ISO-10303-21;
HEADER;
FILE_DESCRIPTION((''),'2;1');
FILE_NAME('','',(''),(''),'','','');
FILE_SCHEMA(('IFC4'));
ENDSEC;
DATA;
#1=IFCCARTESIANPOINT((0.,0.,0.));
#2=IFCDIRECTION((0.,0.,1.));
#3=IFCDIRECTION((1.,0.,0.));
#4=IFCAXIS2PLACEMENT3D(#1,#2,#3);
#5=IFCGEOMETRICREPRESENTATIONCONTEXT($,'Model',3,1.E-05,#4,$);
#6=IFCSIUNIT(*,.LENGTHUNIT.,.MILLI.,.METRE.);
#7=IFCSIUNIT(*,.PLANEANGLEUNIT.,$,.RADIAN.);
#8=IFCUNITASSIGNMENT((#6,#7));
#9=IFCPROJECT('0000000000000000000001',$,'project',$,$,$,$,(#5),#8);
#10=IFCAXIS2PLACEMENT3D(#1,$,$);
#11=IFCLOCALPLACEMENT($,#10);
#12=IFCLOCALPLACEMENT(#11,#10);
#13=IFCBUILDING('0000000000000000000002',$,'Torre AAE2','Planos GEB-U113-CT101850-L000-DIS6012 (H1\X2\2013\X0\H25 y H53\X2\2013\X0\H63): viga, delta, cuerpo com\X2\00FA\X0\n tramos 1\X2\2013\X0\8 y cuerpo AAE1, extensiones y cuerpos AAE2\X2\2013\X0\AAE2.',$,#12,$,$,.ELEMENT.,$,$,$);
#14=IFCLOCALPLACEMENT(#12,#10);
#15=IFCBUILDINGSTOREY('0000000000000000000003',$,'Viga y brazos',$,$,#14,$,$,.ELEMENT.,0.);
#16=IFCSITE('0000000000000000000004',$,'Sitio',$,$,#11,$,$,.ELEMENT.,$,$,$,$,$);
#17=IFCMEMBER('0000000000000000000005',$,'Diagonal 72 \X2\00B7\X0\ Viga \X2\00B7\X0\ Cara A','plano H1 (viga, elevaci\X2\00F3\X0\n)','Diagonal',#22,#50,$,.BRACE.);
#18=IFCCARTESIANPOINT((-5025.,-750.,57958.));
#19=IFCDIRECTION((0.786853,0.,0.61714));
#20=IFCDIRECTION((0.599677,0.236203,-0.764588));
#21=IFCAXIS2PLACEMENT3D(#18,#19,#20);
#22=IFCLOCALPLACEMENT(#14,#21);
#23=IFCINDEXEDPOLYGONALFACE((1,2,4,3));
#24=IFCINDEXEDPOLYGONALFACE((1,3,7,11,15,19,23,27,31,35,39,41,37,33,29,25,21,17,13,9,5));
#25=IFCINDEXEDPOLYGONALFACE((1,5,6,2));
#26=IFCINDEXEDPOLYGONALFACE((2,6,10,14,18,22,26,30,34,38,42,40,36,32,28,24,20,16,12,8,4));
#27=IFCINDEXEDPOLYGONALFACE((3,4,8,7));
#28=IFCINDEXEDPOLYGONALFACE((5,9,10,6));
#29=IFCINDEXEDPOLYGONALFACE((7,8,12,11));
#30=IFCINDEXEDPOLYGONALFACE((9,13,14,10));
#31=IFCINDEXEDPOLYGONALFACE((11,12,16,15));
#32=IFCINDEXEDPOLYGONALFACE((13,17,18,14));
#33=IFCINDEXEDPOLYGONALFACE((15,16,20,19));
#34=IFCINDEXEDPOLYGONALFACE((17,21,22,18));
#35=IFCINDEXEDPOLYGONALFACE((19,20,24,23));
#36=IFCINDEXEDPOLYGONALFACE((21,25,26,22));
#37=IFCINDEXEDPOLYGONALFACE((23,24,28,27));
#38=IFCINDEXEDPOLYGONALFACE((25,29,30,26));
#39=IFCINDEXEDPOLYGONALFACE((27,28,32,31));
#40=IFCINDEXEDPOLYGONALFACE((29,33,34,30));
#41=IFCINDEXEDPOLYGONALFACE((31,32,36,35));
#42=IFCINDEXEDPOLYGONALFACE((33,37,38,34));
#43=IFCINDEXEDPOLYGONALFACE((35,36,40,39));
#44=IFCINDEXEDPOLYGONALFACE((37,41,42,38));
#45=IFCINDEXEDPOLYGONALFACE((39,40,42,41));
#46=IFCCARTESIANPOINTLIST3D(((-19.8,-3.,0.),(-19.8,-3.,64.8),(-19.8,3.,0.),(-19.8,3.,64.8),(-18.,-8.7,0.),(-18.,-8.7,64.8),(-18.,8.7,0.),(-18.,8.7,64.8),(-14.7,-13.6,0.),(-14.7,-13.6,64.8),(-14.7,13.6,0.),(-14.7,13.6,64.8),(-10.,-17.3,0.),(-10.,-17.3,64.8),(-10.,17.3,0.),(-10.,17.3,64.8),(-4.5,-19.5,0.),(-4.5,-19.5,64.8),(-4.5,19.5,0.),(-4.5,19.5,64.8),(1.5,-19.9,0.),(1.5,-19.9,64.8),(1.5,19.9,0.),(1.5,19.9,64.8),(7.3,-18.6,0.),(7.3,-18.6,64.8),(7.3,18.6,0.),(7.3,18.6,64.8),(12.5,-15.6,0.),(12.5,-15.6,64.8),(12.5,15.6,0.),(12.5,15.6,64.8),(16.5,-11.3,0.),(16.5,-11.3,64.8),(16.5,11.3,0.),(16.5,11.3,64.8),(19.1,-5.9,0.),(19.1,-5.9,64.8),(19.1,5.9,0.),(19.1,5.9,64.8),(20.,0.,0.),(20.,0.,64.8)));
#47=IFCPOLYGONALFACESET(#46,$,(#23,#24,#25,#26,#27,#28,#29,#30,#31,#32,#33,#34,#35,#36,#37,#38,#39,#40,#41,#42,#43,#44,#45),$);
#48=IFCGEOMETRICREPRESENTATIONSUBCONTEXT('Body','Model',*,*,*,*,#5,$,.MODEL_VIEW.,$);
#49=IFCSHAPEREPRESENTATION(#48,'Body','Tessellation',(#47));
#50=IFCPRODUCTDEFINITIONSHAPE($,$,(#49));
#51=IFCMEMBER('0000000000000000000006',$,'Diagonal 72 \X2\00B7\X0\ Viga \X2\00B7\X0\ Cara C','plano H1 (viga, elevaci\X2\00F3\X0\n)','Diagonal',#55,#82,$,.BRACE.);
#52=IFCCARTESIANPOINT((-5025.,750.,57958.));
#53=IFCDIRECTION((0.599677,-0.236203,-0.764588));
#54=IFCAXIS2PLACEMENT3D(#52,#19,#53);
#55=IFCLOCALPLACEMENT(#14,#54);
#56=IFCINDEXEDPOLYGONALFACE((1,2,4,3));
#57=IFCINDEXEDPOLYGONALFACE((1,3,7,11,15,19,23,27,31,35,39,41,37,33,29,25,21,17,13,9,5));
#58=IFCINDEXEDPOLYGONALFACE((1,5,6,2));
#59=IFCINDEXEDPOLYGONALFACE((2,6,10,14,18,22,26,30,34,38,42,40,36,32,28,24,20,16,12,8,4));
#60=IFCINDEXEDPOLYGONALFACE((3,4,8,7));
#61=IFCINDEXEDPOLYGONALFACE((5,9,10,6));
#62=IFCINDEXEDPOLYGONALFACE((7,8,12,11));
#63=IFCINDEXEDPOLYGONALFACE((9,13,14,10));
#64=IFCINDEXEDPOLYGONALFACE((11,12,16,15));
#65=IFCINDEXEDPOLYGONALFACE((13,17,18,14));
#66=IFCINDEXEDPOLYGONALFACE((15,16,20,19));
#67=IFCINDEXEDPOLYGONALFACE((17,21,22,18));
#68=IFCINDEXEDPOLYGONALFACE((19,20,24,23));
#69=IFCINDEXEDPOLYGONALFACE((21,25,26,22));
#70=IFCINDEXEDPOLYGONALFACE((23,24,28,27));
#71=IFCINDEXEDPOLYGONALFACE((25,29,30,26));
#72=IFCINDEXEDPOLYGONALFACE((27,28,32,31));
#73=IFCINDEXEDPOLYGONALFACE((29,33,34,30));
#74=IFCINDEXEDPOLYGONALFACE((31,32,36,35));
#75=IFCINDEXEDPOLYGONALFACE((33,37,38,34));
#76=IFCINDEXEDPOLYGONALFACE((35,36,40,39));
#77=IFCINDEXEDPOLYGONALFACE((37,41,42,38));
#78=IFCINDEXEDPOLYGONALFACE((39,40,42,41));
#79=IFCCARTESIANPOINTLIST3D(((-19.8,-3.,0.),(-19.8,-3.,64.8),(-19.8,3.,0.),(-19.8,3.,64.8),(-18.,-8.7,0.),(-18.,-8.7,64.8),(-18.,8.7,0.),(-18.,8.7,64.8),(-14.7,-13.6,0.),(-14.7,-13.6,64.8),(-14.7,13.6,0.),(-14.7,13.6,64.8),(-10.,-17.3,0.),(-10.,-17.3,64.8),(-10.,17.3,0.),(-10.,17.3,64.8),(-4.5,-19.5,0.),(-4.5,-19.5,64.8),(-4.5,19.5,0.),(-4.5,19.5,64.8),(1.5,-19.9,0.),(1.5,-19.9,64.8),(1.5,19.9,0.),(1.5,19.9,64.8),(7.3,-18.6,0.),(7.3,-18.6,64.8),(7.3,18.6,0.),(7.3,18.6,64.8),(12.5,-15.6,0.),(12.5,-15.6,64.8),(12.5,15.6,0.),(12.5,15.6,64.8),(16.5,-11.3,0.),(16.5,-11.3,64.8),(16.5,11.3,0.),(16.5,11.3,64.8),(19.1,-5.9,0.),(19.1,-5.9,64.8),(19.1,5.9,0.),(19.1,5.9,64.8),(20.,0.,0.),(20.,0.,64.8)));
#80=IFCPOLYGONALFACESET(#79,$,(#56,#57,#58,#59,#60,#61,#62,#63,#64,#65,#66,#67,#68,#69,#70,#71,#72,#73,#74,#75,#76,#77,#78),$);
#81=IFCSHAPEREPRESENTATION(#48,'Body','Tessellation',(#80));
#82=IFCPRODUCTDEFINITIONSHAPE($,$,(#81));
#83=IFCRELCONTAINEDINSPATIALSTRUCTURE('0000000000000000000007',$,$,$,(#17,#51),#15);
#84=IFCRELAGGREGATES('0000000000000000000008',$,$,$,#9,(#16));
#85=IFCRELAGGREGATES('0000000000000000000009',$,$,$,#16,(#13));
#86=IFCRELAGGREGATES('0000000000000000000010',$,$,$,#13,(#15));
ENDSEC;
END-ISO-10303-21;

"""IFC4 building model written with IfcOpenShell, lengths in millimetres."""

from ifc_helpers import new_model, si_unit, frame, origin, origin_with_axes, place, context, subcontext, project, spatial, circle, extrude, element, save


model = new_model("IFC4")

# Units and contexts
model_context = context("Model", 3, precision=1e-05, world=origin_with_axes())
body_context = subcontext(model_context, "Body", "Model", "MODEL_VIEW")
ifc_project = project(units=[si_unit("LENGTHUNIT", "METRE", prefix="MILLI"), si_unit("PLANEANGLEUNIT", "RADIAN")], contexts=[model_context])

# Site, building, storey
site_placement = place(None, origin())
site = spatial("IfcSite", under=ifc_project, at=site_placement, Name="Sitio", CompositionType="ELEMENT")
building_placement = place(site_placement, origin())
building = spatial("IfcBuilding", under=site, at=building_placement, Name="Torre AAE2", Description="Planos GEB-U113-CT101850-L000-DIS6012 (H1–H25 y H53–H63): viga, delta, cuerpo común tramos 1–8 y cuerpo AAE1, extensiones y cuerpos AAE2–AAE2.", CompositionType="ELEMENT")
storey_placement = place(building_placement, origin())
storey = spatial("IfcBuildingStorey", under=building, at=storey_placement, Name="Viga y brazos", CompositionType="ELEMENT", Elevation=0.0)

# Members
for number, where, z_axis, x_axis, name in (
    (1, (-5025.0, -750.0, 57958.0), (0.786853, 0.0, 0.61714), (0.599677, 0.236203, -0.764588), "Diagonal 72 · Viga · Cara A"),
    (2, (-5025.0, 750.0, 57958.0), (0.786853, 0.0, 0.61714), (0.599677, -0.236203, -0.764588), "Diagonal 72 · Viga · Cara C"),
):
    element("IfcMember", number, at=place(storey_placement, frame(where, z_axis=z_axis, x_axis=x_axis)), inside=storey, Name=name, Description="plano H1 (viga, elevación)", ObjectType="Diagonal", PredefinedType="BRACE", context=body_context, shape_type="SweptSolid", body=[
        extrude(circle(Radius=20.0), None, (0.0, 0.0, 1.0), 64.8),
    ])

save(model, "model.ifc")
